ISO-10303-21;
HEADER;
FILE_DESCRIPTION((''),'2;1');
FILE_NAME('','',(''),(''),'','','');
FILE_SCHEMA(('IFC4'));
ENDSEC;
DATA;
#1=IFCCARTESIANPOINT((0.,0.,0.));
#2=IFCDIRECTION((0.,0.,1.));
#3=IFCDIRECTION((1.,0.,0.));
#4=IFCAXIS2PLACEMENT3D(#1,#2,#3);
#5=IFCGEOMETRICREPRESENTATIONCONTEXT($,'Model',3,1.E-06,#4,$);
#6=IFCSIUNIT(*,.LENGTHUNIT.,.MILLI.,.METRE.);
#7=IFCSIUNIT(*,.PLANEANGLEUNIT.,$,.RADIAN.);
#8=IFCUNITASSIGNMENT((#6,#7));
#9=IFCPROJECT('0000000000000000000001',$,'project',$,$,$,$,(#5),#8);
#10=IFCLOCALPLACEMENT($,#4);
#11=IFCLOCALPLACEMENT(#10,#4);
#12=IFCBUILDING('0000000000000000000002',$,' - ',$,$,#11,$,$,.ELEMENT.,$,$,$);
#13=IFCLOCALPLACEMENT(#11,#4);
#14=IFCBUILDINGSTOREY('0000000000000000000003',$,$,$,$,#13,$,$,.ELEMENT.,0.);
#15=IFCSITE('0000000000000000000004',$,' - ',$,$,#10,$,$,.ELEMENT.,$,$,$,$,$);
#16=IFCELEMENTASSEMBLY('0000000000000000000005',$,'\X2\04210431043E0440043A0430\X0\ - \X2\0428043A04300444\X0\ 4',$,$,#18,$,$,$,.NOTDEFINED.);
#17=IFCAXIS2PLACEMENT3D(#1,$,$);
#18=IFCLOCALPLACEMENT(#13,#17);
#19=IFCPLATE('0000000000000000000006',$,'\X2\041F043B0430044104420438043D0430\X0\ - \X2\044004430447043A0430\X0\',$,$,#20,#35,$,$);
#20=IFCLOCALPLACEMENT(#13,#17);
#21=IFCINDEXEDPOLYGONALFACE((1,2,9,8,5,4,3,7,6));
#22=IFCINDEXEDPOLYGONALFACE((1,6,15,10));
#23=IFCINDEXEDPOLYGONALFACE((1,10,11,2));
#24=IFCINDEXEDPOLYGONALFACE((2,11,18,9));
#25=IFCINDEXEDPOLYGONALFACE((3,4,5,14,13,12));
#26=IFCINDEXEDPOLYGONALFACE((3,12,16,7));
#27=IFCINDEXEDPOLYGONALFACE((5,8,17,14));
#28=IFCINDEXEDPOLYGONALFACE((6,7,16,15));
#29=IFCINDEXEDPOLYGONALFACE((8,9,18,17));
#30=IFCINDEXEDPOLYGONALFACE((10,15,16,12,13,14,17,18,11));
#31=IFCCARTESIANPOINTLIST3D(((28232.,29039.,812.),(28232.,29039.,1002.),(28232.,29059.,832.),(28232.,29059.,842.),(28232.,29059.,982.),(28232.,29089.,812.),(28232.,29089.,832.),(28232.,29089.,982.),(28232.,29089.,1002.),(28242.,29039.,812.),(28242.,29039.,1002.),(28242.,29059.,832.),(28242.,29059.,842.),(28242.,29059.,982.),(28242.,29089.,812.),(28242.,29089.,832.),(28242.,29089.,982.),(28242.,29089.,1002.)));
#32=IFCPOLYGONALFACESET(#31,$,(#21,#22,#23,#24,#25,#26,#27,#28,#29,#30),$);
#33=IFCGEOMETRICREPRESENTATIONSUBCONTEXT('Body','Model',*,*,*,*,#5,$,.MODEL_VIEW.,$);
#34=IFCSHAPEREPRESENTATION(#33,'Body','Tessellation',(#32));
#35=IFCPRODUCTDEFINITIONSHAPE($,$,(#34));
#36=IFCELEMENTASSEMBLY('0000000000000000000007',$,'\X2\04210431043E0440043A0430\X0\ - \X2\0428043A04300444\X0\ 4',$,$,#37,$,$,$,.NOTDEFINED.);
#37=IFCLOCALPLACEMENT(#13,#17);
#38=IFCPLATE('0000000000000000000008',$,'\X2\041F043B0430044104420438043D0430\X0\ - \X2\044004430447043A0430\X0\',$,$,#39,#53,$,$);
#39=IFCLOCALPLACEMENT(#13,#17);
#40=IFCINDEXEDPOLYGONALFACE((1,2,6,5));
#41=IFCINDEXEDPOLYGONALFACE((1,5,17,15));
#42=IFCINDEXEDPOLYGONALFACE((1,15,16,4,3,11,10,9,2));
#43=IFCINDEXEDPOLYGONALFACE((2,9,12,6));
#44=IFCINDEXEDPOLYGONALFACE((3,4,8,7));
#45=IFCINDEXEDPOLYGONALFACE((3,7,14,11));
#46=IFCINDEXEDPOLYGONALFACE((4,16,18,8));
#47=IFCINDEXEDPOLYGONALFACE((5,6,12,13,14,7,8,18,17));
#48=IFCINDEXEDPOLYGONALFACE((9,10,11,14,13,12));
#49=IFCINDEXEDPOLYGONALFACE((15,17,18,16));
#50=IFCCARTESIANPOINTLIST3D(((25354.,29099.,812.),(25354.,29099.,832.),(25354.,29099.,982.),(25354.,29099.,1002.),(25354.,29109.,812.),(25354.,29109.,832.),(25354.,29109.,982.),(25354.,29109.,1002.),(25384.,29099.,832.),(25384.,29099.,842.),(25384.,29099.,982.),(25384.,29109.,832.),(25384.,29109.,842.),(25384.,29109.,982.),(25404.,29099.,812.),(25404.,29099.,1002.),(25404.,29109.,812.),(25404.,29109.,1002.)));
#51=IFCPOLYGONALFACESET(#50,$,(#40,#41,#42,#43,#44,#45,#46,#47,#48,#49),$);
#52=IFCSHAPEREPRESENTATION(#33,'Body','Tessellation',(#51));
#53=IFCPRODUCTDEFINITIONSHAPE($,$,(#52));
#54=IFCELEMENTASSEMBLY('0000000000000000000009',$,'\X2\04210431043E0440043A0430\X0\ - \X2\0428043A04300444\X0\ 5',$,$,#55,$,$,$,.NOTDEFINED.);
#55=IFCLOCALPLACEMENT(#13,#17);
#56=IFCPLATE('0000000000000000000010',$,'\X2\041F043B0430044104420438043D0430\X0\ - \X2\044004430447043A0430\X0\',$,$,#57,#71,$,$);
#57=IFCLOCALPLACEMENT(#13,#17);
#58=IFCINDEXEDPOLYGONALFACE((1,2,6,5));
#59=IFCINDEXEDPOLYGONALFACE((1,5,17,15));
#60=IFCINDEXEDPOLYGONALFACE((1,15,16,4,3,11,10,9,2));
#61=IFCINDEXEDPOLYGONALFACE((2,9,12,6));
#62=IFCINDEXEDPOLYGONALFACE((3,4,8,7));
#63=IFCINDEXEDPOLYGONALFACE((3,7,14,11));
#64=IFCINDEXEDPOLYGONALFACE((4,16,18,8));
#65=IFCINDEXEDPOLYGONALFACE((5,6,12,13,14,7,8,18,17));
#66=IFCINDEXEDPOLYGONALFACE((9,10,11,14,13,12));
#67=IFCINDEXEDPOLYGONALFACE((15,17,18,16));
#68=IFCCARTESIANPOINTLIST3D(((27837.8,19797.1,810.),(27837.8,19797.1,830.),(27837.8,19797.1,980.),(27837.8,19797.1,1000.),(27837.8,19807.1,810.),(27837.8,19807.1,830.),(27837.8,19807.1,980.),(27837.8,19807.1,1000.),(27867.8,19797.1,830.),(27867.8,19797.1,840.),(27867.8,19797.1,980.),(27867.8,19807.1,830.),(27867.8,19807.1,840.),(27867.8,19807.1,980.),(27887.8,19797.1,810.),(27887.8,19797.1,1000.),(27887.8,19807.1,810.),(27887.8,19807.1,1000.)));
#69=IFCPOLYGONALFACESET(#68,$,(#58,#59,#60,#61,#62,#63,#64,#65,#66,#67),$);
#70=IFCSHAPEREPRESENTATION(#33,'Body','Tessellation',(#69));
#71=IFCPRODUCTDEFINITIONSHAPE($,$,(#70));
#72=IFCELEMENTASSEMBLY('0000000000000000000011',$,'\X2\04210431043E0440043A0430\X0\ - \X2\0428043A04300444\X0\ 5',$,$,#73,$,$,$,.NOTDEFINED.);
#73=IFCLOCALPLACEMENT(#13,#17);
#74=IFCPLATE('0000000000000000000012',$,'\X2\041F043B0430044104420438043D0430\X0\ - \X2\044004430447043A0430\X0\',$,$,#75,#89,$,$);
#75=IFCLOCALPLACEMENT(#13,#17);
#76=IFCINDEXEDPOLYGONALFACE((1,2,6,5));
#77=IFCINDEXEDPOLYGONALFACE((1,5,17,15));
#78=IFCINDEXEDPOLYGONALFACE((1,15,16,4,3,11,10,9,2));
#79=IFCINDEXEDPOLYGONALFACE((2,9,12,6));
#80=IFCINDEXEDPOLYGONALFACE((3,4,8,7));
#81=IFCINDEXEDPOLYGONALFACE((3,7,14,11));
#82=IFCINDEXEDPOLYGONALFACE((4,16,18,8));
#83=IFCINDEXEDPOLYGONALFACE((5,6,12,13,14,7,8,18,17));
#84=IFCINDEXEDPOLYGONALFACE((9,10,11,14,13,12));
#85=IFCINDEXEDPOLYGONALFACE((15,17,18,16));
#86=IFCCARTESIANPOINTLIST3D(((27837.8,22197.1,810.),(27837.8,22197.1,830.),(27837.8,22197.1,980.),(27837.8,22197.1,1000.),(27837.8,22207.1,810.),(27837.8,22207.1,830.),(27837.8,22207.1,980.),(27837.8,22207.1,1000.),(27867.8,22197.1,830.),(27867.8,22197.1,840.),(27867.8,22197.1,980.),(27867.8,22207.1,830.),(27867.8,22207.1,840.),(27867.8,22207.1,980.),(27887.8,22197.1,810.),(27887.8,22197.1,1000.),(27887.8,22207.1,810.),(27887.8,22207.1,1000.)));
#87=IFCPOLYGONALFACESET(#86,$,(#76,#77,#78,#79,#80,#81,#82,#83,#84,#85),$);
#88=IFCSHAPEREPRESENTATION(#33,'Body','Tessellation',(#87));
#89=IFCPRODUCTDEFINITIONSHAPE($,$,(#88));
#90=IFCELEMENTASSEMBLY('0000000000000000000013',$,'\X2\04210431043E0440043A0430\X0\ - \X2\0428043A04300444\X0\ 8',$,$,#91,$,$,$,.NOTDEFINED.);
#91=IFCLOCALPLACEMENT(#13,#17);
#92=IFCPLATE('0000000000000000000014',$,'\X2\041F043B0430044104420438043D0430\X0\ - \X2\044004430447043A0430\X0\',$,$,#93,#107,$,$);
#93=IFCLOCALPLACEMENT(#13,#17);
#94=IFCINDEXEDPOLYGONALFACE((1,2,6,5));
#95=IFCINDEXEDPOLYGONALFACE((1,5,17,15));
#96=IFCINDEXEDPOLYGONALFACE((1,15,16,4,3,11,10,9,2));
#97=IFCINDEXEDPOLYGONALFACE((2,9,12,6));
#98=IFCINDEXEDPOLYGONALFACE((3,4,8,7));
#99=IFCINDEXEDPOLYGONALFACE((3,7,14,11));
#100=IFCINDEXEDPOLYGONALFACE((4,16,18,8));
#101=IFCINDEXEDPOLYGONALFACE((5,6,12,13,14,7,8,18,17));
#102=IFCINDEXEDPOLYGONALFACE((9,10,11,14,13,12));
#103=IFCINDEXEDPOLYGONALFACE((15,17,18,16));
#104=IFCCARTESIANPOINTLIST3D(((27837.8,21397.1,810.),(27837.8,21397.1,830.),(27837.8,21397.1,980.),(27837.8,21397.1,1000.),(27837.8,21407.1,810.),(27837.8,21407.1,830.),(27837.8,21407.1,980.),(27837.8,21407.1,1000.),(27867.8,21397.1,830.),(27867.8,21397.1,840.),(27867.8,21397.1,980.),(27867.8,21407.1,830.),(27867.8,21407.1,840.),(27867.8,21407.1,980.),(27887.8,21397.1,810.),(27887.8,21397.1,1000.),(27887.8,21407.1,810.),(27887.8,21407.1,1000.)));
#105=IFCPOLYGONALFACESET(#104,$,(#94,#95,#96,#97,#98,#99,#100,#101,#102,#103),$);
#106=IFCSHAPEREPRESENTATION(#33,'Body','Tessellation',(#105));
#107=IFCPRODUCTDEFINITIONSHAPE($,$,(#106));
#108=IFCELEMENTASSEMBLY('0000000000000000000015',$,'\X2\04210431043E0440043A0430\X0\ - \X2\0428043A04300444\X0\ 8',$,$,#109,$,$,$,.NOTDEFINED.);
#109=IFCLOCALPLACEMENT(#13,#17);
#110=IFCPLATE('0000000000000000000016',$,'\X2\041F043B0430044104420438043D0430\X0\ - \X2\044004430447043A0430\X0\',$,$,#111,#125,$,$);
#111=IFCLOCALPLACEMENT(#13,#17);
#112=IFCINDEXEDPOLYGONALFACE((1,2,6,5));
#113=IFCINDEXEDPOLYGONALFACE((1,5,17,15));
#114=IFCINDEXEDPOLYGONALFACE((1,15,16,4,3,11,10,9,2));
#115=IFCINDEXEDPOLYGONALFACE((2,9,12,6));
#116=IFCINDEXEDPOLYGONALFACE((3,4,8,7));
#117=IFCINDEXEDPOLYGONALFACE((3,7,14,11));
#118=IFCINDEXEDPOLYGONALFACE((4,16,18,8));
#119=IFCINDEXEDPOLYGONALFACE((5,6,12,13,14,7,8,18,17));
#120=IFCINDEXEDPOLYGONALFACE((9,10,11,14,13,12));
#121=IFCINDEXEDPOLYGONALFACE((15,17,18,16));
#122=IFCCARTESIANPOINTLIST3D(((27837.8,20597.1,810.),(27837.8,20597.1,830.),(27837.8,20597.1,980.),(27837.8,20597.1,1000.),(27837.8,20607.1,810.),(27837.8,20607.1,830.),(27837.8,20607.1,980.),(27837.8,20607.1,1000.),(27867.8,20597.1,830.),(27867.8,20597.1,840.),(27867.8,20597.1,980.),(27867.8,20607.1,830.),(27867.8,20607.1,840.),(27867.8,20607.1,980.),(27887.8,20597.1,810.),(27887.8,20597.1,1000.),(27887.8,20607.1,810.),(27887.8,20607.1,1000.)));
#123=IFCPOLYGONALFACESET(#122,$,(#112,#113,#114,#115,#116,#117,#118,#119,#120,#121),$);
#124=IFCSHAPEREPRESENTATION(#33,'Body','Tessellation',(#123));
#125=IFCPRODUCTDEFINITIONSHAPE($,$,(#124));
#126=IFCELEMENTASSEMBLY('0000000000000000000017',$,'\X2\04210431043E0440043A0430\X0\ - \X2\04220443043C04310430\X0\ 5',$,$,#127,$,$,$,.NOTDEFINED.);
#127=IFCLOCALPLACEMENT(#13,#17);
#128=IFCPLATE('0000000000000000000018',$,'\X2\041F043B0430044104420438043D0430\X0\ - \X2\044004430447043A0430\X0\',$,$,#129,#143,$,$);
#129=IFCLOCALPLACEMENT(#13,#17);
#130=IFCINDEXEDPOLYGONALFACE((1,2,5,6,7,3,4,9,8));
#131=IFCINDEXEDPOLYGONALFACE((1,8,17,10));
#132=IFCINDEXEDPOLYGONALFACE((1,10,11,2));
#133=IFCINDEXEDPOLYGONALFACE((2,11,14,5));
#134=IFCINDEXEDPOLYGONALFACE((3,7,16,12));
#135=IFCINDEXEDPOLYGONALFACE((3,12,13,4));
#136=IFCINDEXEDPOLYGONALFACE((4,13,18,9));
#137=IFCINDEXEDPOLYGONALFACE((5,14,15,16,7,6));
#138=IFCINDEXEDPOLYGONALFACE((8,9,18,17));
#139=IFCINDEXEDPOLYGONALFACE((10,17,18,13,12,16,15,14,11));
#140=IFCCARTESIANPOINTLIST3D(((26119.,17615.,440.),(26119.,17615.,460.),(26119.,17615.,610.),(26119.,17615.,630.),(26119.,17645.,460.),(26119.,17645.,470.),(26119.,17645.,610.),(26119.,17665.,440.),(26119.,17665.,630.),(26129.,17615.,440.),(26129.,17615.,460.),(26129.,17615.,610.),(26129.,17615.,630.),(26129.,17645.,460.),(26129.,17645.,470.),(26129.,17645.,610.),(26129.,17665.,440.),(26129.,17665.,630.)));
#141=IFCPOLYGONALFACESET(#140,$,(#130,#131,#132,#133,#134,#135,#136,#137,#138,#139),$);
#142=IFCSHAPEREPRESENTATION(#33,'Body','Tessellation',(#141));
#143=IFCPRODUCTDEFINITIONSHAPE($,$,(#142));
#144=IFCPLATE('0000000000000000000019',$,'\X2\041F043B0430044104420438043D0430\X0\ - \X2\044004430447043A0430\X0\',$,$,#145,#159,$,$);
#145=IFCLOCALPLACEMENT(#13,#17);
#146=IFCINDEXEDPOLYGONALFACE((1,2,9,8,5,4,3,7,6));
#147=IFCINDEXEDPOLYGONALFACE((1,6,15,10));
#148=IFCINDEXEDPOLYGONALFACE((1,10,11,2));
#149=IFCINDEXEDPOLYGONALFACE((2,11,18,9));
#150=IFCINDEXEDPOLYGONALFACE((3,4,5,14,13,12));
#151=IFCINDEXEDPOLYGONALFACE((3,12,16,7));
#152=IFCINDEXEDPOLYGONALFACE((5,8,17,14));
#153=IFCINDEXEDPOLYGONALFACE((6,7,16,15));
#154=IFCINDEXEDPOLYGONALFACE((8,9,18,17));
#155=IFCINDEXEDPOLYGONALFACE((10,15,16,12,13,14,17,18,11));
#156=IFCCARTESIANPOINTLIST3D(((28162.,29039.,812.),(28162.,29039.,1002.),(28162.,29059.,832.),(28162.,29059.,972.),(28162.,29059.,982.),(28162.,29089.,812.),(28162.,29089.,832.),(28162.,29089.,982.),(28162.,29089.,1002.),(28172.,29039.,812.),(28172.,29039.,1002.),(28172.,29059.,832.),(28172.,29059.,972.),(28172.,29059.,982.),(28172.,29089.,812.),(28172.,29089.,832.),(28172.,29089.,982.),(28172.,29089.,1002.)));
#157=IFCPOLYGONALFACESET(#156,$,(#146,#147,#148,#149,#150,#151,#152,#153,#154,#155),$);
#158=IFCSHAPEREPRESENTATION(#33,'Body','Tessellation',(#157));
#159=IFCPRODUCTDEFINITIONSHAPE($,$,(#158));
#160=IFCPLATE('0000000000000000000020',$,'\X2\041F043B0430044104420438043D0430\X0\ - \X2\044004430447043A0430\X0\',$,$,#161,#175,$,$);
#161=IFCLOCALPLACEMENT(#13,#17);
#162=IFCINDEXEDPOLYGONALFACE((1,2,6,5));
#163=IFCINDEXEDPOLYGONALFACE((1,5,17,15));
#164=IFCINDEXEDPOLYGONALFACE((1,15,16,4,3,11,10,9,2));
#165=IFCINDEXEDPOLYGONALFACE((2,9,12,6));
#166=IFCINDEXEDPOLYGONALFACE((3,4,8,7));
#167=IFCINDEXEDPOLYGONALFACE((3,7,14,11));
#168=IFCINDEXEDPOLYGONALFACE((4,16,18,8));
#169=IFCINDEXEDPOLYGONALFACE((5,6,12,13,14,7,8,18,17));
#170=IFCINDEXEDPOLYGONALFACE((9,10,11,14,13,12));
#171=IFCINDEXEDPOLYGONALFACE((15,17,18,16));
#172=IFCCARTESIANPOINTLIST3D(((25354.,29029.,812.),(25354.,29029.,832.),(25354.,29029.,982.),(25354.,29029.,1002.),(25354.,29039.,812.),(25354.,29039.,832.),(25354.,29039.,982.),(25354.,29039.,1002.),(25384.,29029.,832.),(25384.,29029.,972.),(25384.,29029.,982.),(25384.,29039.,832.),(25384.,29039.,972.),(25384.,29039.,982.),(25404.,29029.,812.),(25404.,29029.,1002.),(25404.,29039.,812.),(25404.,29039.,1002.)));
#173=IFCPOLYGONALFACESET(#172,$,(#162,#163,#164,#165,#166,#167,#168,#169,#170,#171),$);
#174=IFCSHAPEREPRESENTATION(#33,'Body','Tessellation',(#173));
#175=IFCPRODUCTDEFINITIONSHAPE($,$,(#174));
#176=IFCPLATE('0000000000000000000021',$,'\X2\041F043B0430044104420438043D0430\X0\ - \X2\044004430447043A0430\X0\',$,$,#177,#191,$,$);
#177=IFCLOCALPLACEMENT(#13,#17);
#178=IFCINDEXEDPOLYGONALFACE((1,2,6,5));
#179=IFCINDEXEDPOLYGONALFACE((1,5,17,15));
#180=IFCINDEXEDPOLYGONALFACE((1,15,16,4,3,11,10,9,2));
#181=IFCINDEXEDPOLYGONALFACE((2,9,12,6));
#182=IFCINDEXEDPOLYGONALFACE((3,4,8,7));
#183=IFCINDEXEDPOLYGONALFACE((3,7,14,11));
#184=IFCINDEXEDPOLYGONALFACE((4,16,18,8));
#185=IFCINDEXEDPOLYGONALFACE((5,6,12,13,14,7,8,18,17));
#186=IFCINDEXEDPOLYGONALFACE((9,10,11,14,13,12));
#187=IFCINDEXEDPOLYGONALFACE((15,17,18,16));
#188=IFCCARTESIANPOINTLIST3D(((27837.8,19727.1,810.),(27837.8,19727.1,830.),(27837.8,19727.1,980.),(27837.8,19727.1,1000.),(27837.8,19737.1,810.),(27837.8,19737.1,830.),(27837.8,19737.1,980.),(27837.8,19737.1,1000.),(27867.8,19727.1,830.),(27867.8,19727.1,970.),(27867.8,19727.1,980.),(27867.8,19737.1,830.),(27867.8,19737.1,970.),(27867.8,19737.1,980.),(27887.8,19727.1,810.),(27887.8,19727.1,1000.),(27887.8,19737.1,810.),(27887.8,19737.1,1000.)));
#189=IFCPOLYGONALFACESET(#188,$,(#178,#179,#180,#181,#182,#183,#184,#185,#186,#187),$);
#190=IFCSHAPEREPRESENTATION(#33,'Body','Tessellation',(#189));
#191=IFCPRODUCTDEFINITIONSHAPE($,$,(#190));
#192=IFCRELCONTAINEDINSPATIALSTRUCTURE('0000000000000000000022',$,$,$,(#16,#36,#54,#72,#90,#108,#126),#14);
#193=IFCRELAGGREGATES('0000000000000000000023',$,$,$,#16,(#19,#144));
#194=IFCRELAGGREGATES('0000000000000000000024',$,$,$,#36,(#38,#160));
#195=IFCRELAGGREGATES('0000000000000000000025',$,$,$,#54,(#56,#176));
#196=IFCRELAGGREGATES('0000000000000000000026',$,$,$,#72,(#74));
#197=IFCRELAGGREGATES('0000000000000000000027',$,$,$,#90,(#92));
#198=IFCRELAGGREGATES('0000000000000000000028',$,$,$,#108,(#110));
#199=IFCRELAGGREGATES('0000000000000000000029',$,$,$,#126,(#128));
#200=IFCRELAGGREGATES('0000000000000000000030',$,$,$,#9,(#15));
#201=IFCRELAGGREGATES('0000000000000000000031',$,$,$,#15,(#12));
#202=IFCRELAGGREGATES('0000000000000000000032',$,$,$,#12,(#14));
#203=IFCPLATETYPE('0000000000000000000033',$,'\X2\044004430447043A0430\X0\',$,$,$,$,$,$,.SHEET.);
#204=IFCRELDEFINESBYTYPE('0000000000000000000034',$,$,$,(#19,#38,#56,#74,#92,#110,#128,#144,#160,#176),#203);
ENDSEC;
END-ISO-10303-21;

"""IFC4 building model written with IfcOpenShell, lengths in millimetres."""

from ifc_helpers import new_model, si_unit, frame, origin_with_axes, place, context, subcontext, project, spatial, line, indexed_curve, outline, extrude, source, transform, mapped, type_object, element, aggregate, save


model = new_model("IFC4")

# Units and contexts
model_context = context("Model", 3, precision=1e-06, world=origin_with_axes())
body_context = subcontext(model_context, "Body", "Model", "MODEL_VIEW")
ifc_project = project(units=[si_unit("LENGTHUNIT", "METRE", prefix="MILLI"), si_unit("PLANEANGLEUNIT", "RADIAN")], contexts=[model_context])

# Site, building, storey
site_placement = place(None, origin_with_axes())
site = spatial("IfcSite", under=ifc_project, at=site_placement, Name=" - ", CompositionType="ELEMENT")
building_placement = place(site_placement, origin_with_axes())
building = spatial("IfcBuilding", under=site, at=building_placement, Name=" - ", CompositionType="ELEMENT")
storey_placement = place(building_placement, origin_with_axes())
storey = spatial("IfcBuildingStorey", under=building, at=storey_placement, CompositionType="ELEMENT", Elevation=0.0)

# Shared definitions
plate_type = type_object("IfcPlateType", Name="ручка", PredefinedType="SHEET")

# Element assemblies, plates
assembly_1_placement = place(storey_placement, frame((27602.0, 29089.0, 2.0), z_axis=(0.0, 0.0, 1.0), x_axis=(1.0, 0.0, 0.0)))
assembly_1 = element("IfcElementAssembly", 1, at=assembly_1_placement, inside=storey, Name="Сборка - Шкаф 4", PredefinedType="NOTDEFINED")
shared_shape_1 = source(origin_with_axes(), body_context, "Body", "SweptSolid", [
    extrude(outline(indexed_curve([(-95.0, -25.0), (-75.0, -25.0), (-75.0, 5.0), (-65.0, 5.0), (75.0, 5.0), (75.0, -25.0), (95.0, -25.0), (95.0, 25.0), (-95.0, 25.0)], segments=[line(1, 2), line(2, 3), line(3, 4), line(4, 5), line(5, 6), line(6, 7), line(7, 8), line(8, 9), line(9, 1)])), origin_with_axes(), (0.0, 0.0, 1.0), 10.0),
])
plate_1_placement = place(assembly_1_placement, frame((630.0, -25.0, 905.0), z_axis=(1.0, 0.0, 0.0), x_axis=(0.0, 0.0, 1.0)))
plate_1 = element("IfcPlate", 2, at=plate_1_placement, type_object=plate_type, Name="Пластина - ручка", context=body_context, shape_type="MappedRepresentation", body=[
    mapped(shared_shape_1, transform((0.0, 0.0, 0.0), x_axis=(1.0, 0.0, 0.0), y_axis=(0.0, 1.0, 0.0), z_axis=(0.0, 0.0, 1.0), scale=1.0)),
])
assembly_2_placement = place(storey_placement, frame((25354.0, 28469.0, 2.0), z_axis=(0.0, 0.0, 1.0), x_axis=(0.0, 1.0, 0.0)))
assembly_2 = element("IfcElementAssembly", 3, at=assembly_2_placement, inside=storey, Name="Сборка - Шкаф 4", PredefinedType="NOTDEFINED")
plate_2_placement = place(assembly_2_placement, frame((630.0, -25.0, 905.0), z_axis=(1.0, 0.0, 0.0), x_axis=(0.0, 0.0, 1.0)))
plate_2 = element("IfcPlate", 4, at=plate_2_placement, type_object=plate_type, Name="Пластина - ручка", context=body_context, shape_type="MappedRepresentation", body=[
    mapped(shared_shape_1, transform((0.0, 0.0, 0.0), x_axis=(1.0, 0.0, 0.0), y_axis=(0.0, 1.0, 0.0), z_axis=(0.0, 0.0, 1.0), scale=1.0)),
])
assembly_3_placement = place(storey_placement, frame((27837.8, 19367.1, 0.0), z_axis=(0.0, 0.0, 1.0), x_axis=(0.0, 1.0, 0.0)))
assembly_3 = element("IfcElementAssembly", 5, at=assembly_3_placement, inside=storey, Name="Сборка - Шкаф 5", PredefinedType="NOTDEFINED")
plate_3_placement = place(assembly_3_placement, frame((430.0, -25.0, 905.0), z_axis=(1.0, 0.0, 0.0), x_axis=(0.0, 0.0, 1.0)))
plate_3 = element("IfcPlate", 6, at=plate_3_placement, type_object=plate_type, Name="Пластина - ручка", context=body_context, shape_type="MappedRepresentation", body=[
    mapped(shared_shape_1, transform((0.0, 0.0, 0.0), x_axis=(1.0, 0.0, 0.0), y_axis=(0.0, 1.0, 0.0), z_axis=(0.0, 0.0, 1.0), scale=1.0)),
])
assembly_4_placement = place(storey_placement, frame((27837.8, 21767.1, 0.0), z_axis=(0.0, 0.0, 1.0), x_axis=(0.0, 1.0, 0.0)))
assembly_4 = element("IfcElementAssembly", 7, at=assembly_4_placement, inside=storey, Name="Сборка - Шкаф 5", PredefinedType="NOTDEFINED")
plate_4_placement = place(assembly_4_placement, frame((430.0, -25.0, 905.0), z_axis=(1.0, 0.0, 0.0), x_axis=(0.0, 0.0, 1.0)))
plate_4 = element("IfcPlate", 8, at=plate_4_placement, type_object=plate_type, Name="Пластина - ручка", context=body_context, shape_type="MappedRepresentation", body=[
    mapped(shared_shape_1, transform((0.0, 0.0, 0.0), x_axis=(1.0, 0.0, 0.0), y_axis=(0.0, 1.0, 0.0), z_axis=(0.0, 0.0, 1.0), scale=1.0)),
])
assembly_5_placement = place(storey_placement, frame((27837.8, 20967.1, 0.0), z_axis=(0.0, 0.0, 1.0), x_axis=(0.0, 1.0, 0.0)))
assembly_5 = element("IfcElementAssembly", 9, at=assembly_5_placement, inside=storey, Name="Сборка - Шкаф 8", PredefinedType="NOTDEFINED")
plate_5_placement = place(assembly_5_placement, frame((430.0, -25.0, 905.0), z_axis=(1.0, 0.0, 0.0), x_axis=(0.0, 0.0, 1.0)))
plate_5 = element("IfcPlate", 10, at=plate_5_placement, type_object=plate_type, Name="Пластина - ручка", context=body_context, shape_type="MappedRepresentation", body=[
    mapped(shared_shape_1, transform((0.0, 0.0, 0.0), x_axis=(1.0, 0.0, 0.0), y_axis=(0.0, 1.0, 0.0), z_axis=(0.0, 0.0, 1.0), scale=1.0)),
])
assembly_6_placement = place(storey_placement, frame((27837.8, 20167.1, 0.0), z_axis=(0.0, 0.0, 1.0), x_axis=(0.0, 1.0, 0.0)))
assembly_6 = element("IfcElementAssembly", 11, at=assembly_6_placement, inside=storey, Name="Сборка - Шкаф 8", PredefinedType="NOTDEFINED")
plate_6_placement = place(assembly_6_placement, frame((430.0, -25.0, 905.0), z_axis=(1.0, 0.0, 0.0), x_axis=(0.0, 0.0, 1.0)))
plate_6 = element("IfcPlate", 12, at=plate_6_placement, type_object=plate_type, Name="Пластина - ручка", context=body_context, shape_type="MappedRepresentation", body=[
    mapped(shared_shape_1, transform((0.0, 0.0, 0.0), x_axis=(1.0, 0.0, 0.0), y_axis=(0.0, 1.0, 0.0), z_axis=(0.0, 0.0, 1.0), scale=1.0)),
])
assembly_7_placement = place(storey_placement, frame((25449.0, 17430.0, 0.0), z_axis=(0.0, 0.0, 1.0), x_axis=(-1.0, 0.0, 0.0)))
assembly_7 = element("IfcElementAssembly", 13, at=assembly_7_placement, inside=storey, Name="Сборка - Тумба 5", PredefinedType="NOTDEFINED")
plate_7_placement = place(assembly_7_placement, frame((-680.0, -210.0, 535.0), z_axis=(1.0, 0.0, 0.0), x_axis=(0.0, 0.0, 1.0)))
plate_7 = element("IfcPlate", 14, at=plate_7_placement, type_object=plate_type, Name="Пластина - ручка", context=body_context, shape_type="MappedRepresentation", body=[
    mapped(shared_shape_1, transform((0.0, 0.0, 0.0), x_axis=(1.0, 0.0, 0.0), y_axis=(0.0, 1.0, 0.0), z_axis=(0.0, 0.0, 1.0), scale=1.0)),
])

# Plates
shared_shape_2 = source(origin_with_axes(), body_context, "Body", "SweptSolid", [
    extrude(outline(indexed_curve([(-95.0, -25.0), (-75.0, -25.0), (-75.0, 5.0), (-65.0, 5.0), (75.0, 5.0), (75.0, -25.0), (95.0, -25.0), (95.0, 25.0), (-95.0, 25.0)], segments=[line(1, 2), line(2, 3), line(3, 4), line(4, 5), line(5, 6), line(6, 7), line(7, 8), line(8, 9), line(9, 1)])), origin_with_axes(), (0.0, 0.0, 1.0), 10.0),
])
plate_8_placement = place(assembly_1_placement, frame((570.0, -25.0, 905.0), z_axis=(-1.0, 0.0, 0.0), x_axis=(0.0, 0.0, -1.0)))
plate_8 = element("IfcPlate", 15, at=plate_8_placement, type_object=plate_type, Name="Пластина - ручка", context=body_context, shape_type="MappedRepresentation", body=[
    mapped(shared_shape_2, transform((0.0, 0.0, 0.0), x_axis=(1.0, 0.0, 0.0), y_axis=(0.0, 1.0, 0.0), z_axis=(0.0, 0.0, 1.0), scale=1.0)),
])
aggregate(assembly_1, [plate_1, plate_8])
plate_9_placement = place(assembly_2_placement, frame((570.0, -25.0, 905.0), z_axis=(-1.0, 0.0, 0.0), x_axis=(0.0, 0.0, -1.0)))
plate_9 = element("IfcPlate", 16, at=plate_9_placement, type_object=plate_type, Name="Пластина - ручка", context=body_context, shape_type="MappedRepresentation", body=[
    mapped(shared_shape_2, transform((0.0, 0.0, 0.0), x_axis=(1.0, 0.0, 0.0), y_axis=(0.0, 1.0, 0.0), z_axis=(0.0, 0.0, 1.0), scale=1.0)),
])
aggregate(assembly_2, [plate_2, plate_9])
plate_10_placement = place(assembly_3_placement, frame((370.0, -25.0, 905.0), z_axis=(-1.0, 0.0, 0.0), x_axis=(0.0, 0.0, -1.0)))
plate_10 = element("IfcPlate", 17, at=plate_10_placement, type_object=plate_type, Name="Пластина - ручка", context=body_context, shape_type="MappedRepresentation", body=[
    mapped(shared_shape_2, transform((0.0, 0.0, 0.0), x_axis=(1.0, 0.0, 0.0), y_axis=(0.0, 1.0, 0.0), z_axis=(0.0, 0.0, 1.0), scale=1.0)),
])
aggregate(assembly_3, [plate_3, plate_10])
aggregate(assembly_4, [plate_4])
aggregate(assembly_5, [plate_5])
aggregate(assembly_6, [plate_6])
aggregate(assembly_7, [plate_7])

save(model, "model.ifc")
